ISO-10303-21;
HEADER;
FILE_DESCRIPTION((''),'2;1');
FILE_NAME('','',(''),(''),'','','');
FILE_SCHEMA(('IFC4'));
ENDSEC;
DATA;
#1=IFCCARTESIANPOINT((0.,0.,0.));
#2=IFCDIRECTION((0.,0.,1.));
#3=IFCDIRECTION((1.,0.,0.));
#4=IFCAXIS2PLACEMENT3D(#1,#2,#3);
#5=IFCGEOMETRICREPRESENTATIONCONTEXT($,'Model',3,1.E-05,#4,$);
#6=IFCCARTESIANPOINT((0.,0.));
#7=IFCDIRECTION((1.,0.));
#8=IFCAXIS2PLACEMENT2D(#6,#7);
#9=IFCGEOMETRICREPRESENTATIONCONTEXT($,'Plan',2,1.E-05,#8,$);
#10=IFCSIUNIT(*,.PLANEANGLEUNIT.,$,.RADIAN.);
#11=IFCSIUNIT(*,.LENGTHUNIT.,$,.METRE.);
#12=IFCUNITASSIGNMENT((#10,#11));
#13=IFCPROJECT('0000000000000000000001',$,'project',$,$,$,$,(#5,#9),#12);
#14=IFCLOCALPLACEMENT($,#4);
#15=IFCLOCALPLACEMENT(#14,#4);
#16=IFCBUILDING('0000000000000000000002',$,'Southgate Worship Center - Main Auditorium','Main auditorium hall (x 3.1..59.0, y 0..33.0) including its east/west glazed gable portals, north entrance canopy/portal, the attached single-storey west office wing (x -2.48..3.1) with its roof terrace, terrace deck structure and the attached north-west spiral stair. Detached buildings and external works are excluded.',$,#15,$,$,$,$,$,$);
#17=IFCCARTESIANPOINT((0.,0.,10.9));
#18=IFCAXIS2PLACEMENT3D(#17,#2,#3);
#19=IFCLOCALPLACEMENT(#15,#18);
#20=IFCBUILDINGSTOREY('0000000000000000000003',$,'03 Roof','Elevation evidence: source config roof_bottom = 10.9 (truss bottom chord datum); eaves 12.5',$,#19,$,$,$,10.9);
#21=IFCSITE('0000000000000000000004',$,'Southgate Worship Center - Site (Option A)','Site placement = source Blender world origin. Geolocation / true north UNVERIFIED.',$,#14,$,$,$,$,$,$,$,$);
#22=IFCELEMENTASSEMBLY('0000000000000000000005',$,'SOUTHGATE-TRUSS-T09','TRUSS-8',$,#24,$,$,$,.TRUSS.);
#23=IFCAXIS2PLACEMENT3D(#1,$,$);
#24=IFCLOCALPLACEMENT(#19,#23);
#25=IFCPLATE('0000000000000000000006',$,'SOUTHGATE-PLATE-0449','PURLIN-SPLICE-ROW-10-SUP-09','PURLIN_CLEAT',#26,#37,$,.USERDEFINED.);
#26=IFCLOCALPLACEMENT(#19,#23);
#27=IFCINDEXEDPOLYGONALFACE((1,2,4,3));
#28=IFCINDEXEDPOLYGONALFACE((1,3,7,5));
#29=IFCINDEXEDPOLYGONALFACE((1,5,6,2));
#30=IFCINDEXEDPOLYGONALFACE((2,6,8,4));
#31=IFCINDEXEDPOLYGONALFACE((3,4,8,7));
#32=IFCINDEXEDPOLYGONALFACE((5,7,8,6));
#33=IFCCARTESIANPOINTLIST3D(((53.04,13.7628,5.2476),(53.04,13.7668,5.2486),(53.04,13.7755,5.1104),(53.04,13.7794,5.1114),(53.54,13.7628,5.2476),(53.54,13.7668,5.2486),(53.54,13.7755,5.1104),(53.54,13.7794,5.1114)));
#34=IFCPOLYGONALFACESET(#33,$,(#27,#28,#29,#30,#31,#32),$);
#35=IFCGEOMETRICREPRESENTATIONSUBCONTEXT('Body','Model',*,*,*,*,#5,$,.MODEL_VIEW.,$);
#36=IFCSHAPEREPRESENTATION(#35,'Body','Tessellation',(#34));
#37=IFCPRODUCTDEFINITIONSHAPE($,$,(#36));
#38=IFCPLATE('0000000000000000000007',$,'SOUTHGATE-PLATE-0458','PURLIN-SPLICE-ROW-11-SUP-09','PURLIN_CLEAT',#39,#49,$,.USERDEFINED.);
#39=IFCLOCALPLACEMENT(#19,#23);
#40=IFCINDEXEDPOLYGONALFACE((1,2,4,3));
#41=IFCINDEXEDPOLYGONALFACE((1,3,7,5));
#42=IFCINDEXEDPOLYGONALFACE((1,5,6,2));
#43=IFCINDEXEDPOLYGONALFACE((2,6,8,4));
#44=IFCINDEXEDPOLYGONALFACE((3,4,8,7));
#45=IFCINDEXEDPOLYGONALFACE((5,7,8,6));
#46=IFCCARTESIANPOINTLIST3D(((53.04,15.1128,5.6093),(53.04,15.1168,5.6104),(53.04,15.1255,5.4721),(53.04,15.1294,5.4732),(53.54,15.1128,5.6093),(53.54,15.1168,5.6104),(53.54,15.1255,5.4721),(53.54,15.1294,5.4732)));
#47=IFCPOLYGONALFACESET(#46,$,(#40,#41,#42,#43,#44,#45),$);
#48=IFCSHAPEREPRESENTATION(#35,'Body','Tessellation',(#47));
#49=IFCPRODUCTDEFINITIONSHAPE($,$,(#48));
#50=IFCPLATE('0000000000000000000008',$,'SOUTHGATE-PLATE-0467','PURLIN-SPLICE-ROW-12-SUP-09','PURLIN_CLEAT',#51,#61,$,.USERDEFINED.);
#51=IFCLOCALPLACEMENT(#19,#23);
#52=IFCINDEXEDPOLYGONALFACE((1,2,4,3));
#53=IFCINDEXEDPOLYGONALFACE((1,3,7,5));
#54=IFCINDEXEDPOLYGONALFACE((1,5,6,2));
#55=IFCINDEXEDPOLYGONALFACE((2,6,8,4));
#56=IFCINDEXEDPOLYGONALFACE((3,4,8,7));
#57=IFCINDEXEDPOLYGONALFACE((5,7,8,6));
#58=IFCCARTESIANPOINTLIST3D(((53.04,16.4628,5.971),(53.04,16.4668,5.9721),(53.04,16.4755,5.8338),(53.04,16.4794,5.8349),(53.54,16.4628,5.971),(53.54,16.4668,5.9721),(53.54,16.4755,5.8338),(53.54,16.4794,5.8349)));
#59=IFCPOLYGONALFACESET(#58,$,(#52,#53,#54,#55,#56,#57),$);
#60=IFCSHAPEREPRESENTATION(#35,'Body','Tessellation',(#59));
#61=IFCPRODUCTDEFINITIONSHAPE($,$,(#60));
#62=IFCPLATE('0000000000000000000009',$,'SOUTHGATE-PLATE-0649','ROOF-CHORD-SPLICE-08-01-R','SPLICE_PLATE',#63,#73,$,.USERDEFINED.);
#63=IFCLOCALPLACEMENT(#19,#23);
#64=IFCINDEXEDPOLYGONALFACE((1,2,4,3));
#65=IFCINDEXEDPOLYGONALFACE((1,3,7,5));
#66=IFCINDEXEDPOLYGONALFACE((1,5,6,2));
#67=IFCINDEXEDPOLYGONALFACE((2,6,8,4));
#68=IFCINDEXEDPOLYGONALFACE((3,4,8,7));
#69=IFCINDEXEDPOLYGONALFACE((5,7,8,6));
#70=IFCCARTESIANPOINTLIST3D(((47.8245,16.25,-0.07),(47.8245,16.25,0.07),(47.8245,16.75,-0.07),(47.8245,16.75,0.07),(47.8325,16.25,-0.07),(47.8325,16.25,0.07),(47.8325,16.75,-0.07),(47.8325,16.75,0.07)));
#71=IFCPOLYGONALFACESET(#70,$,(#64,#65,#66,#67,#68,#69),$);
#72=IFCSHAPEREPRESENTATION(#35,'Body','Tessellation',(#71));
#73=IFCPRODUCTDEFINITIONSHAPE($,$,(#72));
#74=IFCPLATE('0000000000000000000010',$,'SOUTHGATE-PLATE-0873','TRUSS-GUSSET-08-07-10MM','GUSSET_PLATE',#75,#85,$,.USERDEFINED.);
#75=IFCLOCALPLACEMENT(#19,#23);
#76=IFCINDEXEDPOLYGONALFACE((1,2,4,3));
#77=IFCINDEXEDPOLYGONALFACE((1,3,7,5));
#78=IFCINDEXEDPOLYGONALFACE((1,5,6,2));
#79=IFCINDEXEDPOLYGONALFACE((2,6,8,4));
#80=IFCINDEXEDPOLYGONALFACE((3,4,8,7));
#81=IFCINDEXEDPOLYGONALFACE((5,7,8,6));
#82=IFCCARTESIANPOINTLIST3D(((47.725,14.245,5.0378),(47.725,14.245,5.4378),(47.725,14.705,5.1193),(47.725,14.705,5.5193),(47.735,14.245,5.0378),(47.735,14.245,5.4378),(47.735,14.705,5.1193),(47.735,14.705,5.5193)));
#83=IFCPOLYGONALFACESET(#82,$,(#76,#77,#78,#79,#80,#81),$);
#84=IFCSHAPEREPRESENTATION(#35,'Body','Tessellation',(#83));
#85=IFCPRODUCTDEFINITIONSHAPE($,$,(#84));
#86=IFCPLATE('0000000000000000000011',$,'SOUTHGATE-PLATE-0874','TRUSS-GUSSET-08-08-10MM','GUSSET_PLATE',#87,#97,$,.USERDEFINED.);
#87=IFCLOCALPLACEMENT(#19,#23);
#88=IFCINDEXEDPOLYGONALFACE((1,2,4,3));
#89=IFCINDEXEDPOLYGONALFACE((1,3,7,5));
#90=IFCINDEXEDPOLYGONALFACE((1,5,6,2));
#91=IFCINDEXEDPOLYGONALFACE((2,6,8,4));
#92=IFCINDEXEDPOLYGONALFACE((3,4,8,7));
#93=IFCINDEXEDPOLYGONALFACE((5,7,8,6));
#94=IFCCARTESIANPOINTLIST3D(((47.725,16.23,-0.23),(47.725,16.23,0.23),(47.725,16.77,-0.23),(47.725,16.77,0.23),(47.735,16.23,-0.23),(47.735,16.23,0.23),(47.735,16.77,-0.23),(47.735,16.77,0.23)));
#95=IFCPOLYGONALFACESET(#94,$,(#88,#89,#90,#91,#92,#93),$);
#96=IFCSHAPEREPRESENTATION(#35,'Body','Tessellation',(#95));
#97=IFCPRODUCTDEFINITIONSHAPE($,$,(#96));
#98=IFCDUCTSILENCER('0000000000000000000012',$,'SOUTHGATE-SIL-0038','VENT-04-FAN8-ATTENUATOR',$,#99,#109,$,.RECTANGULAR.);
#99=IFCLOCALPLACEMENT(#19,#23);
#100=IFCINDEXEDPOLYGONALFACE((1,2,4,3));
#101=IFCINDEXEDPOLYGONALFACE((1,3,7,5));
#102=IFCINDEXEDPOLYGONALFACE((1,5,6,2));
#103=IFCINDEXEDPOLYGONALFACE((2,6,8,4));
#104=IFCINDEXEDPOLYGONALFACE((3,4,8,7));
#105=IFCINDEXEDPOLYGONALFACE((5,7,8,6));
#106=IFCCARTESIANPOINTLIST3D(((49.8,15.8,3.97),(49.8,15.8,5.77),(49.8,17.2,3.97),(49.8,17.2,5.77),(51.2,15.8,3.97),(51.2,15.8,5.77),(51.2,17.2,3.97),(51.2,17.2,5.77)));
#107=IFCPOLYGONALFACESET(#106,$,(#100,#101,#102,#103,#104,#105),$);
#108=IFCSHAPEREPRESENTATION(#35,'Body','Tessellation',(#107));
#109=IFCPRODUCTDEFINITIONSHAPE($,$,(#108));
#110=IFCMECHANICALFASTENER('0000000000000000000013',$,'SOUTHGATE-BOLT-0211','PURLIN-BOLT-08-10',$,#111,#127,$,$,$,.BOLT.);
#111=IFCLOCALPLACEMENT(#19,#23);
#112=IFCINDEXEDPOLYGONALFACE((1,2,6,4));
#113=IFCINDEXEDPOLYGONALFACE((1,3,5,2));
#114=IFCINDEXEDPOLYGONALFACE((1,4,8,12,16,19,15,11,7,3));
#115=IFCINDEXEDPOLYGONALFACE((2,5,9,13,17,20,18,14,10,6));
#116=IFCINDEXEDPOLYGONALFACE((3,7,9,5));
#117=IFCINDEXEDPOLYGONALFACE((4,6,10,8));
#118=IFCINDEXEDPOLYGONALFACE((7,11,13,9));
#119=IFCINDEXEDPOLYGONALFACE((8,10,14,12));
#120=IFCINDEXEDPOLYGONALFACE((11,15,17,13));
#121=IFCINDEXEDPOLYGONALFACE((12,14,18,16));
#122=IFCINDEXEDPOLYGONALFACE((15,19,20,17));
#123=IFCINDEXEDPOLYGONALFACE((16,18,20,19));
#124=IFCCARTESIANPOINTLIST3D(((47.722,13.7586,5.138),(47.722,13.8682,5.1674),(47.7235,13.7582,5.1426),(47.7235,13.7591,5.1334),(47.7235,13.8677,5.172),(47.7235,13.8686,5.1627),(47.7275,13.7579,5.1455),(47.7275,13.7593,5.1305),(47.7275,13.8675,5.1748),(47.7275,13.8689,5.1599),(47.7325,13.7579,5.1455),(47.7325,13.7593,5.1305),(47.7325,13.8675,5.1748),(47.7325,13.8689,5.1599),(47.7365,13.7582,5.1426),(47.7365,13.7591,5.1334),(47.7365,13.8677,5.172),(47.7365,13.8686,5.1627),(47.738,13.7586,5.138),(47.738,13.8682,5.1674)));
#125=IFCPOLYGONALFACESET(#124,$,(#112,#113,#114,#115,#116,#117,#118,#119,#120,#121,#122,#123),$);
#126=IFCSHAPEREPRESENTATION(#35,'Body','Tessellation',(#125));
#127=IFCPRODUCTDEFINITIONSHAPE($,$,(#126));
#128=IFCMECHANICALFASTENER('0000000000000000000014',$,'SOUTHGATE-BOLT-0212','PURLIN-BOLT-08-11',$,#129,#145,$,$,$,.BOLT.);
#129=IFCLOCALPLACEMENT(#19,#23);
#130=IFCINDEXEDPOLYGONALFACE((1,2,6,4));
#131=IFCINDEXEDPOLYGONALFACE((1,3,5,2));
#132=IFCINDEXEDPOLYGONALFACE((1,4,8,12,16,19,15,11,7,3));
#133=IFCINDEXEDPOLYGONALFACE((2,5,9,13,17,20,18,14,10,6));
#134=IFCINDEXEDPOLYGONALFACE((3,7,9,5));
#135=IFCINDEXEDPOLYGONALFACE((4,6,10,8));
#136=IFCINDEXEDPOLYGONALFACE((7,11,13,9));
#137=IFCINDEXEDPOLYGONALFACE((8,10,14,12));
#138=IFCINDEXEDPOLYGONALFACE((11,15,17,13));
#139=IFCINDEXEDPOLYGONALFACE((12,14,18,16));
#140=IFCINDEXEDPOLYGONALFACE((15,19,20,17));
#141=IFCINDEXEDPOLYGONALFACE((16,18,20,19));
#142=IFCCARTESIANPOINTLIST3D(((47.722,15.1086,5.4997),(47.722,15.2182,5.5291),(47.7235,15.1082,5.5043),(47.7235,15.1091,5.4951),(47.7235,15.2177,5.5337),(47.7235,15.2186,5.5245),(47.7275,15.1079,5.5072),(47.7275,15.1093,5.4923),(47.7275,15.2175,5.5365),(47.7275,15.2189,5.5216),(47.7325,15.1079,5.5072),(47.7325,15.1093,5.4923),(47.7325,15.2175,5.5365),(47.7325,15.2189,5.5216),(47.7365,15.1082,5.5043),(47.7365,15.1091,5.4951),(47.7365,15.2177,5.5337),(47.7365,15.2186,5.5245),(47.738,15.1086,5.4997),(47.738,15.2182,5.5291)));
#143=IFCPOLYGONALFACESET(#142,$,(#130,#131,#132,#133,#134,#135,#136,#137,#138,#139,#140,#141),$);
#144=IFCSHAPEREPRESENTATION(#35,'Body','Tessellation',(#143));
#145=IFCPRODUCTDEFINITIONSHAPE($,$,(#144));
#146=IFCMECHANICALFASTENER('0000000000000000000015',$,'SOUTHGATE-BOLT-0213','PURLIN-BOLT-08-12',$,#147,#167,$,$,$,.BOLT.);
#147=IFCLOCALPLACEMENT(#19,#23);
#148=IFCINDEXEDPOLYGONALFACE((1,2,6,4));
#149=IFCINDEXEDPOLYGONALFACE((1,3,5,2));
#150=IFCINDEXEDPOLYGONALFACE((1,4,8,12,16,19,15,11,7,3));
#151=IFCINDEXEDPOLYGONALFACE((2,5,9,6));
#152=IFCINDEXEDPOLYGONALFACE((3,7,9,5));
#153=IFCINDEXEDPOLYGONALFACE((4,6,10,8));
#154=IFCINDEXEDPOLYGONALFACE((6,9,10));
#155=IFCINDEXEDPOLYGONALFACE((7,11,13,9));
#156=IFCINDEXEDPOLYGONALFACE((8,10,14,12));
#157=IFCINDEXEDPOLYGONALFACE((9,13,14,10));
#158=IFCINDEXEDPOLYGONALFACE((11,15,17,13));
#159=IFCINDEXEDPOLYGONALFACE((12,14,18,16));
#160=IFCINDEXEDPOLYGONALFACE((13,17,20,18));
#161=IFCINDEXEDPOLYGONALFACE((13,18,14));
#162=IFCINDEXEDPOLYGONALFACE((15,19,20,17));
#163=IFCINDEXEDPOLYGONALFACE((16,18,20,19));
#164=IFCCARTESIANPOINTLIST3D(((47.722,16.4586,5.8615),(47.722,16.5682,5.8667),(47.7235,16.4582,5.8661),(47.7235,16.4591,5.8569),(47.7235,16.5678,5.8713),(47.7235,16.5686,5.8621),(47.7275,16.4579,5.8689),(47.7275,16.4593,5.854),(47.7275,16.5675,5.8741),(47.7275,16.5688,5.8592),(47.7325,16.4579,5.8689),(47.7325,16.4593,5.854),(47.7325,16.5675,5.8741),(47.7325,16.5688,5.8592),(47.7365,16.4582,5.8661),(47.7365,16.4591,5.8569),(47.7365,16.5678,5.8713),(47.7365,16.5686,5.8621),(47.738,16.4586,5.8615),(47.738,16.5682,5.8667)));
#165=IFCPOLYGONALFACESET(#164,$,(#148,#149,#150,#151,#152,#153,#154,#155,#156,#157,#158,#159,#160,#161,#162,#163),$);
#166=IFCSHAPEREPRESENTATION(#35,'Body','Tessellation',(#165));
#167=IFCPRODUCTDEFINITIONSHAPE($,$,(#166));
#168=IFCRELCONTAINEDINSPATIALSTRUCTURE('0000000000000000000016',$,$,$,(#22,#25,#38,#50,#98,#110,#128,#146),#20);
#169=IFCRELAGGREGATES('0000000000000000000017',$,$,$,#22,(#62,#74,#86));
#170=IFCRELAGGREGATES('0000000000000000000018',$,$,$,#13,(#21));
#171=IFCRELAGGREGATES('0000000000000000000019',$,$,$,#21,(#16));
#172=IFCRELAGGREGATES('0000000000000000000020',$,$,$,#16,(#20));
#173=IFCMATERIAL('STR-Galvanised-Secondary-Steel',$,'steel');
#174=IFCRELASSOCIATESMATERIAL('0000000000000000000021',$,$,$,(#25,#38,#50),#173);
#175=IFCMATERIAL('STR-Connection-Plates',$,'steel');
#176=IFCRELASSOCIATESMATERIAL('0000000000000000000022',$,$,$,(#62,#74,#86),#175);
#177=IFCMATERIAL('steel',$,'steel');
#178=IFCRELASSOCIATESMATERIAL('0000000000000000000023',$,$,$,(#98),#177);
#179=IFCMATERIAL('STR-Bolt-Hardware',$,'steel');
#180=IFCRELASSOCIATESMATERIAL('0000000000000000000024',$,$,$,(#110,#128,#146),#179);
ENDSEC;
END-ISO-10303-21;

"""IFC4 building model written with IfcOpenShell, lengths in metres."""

from ifc_helpers import new_model, si_unit, frame, origin_with_axes, origin_2d, origin_2d_with_axis, place, context, subcontext, project, spatial, indexed_curve, rectangle, outline, extrude, clip, halfspace, material, element, aggregate, save


model = new_model("IFC4")

# Units and contexts
model_context = context("Model", 3, precision=1e-05, world=origin_with_axes())
plan_context = context("Plan", 2, precision=1e-05, world=origin_2d_with_axis())
body_context = subcontext(model_context, "Body", "Model", "MODEL_VIEW")
ifc_project = project(units=[si_unit("PLANEANGLEUNIT", "RADIAN"), si_unit("LENGTHUNIT", "METRE")], contexts=[model_context, plan_context])

# Site, building, storey
site_placement = place(None, origin_with_axes())
site = spatial("IfcSite", under=ifc_project, at=site_placement, Name="Southgate Worship Center - Site (Option A)", Description="Site placement = source Blender world origin. Geolocation / true north UNVERIFIED.")
building_placement = place(site_placement, origin_with_axes())
building = spatial("IfcBuilding", under=site, at=building_placement, Name="Southgate Worship Center - Main Auditorium", Description="Main auditorium hall (x 3.1..59.0, y 0..33.0) including its east/west glazed gable portals, north entrance canopy/portal, the attached single-storey west office wing (x -2.48..3.1) with its roof terrace, terrace deck structure and the attached north-west spiral stair. Detached buildings and external works are excluded.")
storey_placement = place(building_placement, frame((0.0, 0.0, 10.9), z_axis=(0.0, 0.0, 1.0), x_axis=(1.0, 0.0, 0.0)))
storey = spatial("IfcBuildingStorey", under=building, at=storey_placement, Name="03 Roof", Description="Elevation evidence: source config roof_bottom = 10.9 (truss bottom chord datum); eaves 12.5", Elevation=10.9)

# Shared definitions
ifc_material_1 = material(Name="STR-Galvanised-Secondary-Steel", Category="steel")

# Element assembly
assembly_1_placement = place(storey_placement, origin_with_axes())
assembly_1 = element("IfcElementAssembly", 1, at=assembly_1_placement, inside=storey, Name="SOUTHGATE-TRUSS-T09", Description="TRUSS-8", PredefinedType="TRUSS")

# Plates
plate_1_placement = place(storey_placement, frame((53.04, 13.7628, 5.1104), z_axis=(1.0, 0.0, 0.0), x_axis=(0.0, 1.0, 0.0)))
element("IfcPlate", 2, at=plate_1_placement, inside=storey, material=ifc_material_1, Name="SOUTHGATE-PLATE-0449", Description="PURLIN-SPLICE-ROW-10-SUP-09", ObjectType="PURLIN_CLEAT", PredefinedType="USERDEFINED", context=body_context, shape_type="SweptSolid", body=[
    extrude(outline(indexed_curve([(0.0, 0.0), (0.004, 0.0011), (-0.0087, 0.1382), (-0.0127, 0.1372), (0.0, 0.0)], self_intersect=False)), frame((0.0127, 0.0, 0.0), z_axis=(0.0, 0.0, 1.0), x_axis=(1.0, 0.0, 0.0)), (0.0, 0.0, 1.0), 0.5),
])
plate_2_placement = place(storey_placement, frame((53.04, 15.1128, 5.4721), z_axis=(1.0, 0.0, 0.0), x_axis=(0.0, 1.0, 0.0)))
element("IfcPlate", 3, at=plate_2_placement, inside=storey, material=ifc_material_1, Name="SOUTHGATE-PLATE-0458", Description="PURLIN-SPLICE-ROW-11-SUP-09", ObjectType="PURLIN_CLEAT", PredefinedType="USERDEFINED", context=body_context, shape_type="SweptSolid", body=[
    extrude(outline(indexed_curve([(0.0, 0.0), (0.004, 0.0011), (-0.0087, 0.1382), (-0.0127, 0.1372), (0.0, 0.0)], self_intersect=False)), frame((0.0127, 0.0, 0.0), z_axis=(0.0, 0.0, 1.0), x_axis=(1.0, 0.0, 0.0)), (0.0, 0.0, 1.0), 0.5),
])
plate_3_placement = place(storey_placement, frame((53.04, 16.4628, 5.8338), z_axis=(1.0, 0.0, 0.0), x_axis=(0.0, 1.0, 0.0)))
element("IfcPlate", 4, at=plate_3_placement, inside=storey, material=ifc_material_1, Name="SOUTHGATE-PLATE-0467", Description="PURLIN-SPLICE-ROW-12-SUP-09", ObjectType="PURLIN_CLEAT", PredefinedType="USERDEFINED", context=body_context, shape_type="SweptSolid", body=[
    extrude(outline(indexed_curve([(0.0, 0.0), (0.004, 0.0011), (-0.0087, 0.1382), (-0.0127, 0.1372), (0.0, 0.0)], self_intersect=False)), frame((0.0127, 0.0, 0.0), z_axis=(0.0, 0.0, 1.0), x_axis=(1.0, 0.0, 0.0)), (0.0, 0.0, 1.0), 0.5),
])

# Plates
ifc_material_2 = material(Name="STR-Connection-Plates", Category="steel")
plate_4_placement = place(assembly_1_placement, frame((47.8245, 16.25, -0.07), z_axis=(0.0, 0.0, 1.0), x_axis=(1.0, 0.0, 0.0)))
plate_4 = element("IfcPlate", 5, at=plate_4_placement, material=ifc_material_2, Name="SOUTHGATE-PLATE-0649", Description="ROOF-CHORD-SPLICE-08-01-R", ObjectType="SPLICE_PLATE", PredefinedType="USERDEFINED", context=body_context, shape_type="SweptSolid", body=[
    extrude(rectangle(XDim=0.008, YDim=0.5, at=origin_2d()), frame((0.004, 0.25, 0.0), z_axis=(0.0, 0.0, 1.0), x_axis=(1.0, 0.0, 0.0)), (0.0, 0.0, 1.0), 0.14),
])
plate_5_placement = place(assembly_1_placement, frame((47.725, 14.245, 5.0378), z_axis=(1.0, 0.0, 0.0), x_axis=(0.0, 1.0, 0.0)))
plate_5 = element("IfcPlate", 6, at=plate_5_placement, material=ifc_material_2, Name="SOUTHGATE-PLATE-0873", Description="TRUSS-GUSSET-08-07-10MM", ObjectType="GUSSET_PLATE", PredefinedType="USERDEFINED", context=body_context, shape_type="SweptSolid", body=[
    extrude(outline(indexed_curve([(0.0, 0.0), (0.0, 0.4), (-0.46, 0.3186), (-0.46, -0.0814), (0.0, 0.0)], self_intersect=False)), frame((0.46, 0.0814, 0.0), z_axis=(0.0, 0.0, 1.0), x_axis=(1.0, 0.0, 0.0)), (0.0, 0.0, 1.0), 0.01),
])
plate_6_placement = place(assembly_1_placement, frame((47.725, 16.23, -0.23), z_axis=(0.0, 0.0, 1.0), x_axis=(1.0, 0.0, 0.0)))
plate_6 = element("IfcPlate", 7, at=plate_6_placement, material=ifc_material_2, Name="SOUTHGATE-PLATE-0874", Description="TRUSS-GUSSET-08-08-10MM", ObjectType="GUSSET_PLATE", PredefinedType="USERDEFINED", context=body_context, shape_type="SweptSolid", body=[
    extrude(rectangle(XDim=0.01, YDim=0.54, at=origin_2d()), frame((0.005, 0.27, 0.0), z_axis=(0.0, 0.0, 1.0), x_axis=(1.0, 0.0, 0.0)), (0.0, 0.0, 1.0), 0.46),
])

# Duct silencer
ifc_material_3 = material(Name="steel", Category="steel")
duct_silencer_placement = place(storey_placement, frame((49.8, 15.8, 3.97), z_axis=(0.0, 0.0, 1.0), x_axis=(1.0, 0.0, 0.0)))
element("IfcDuctSilencer", 8, at=duct_silencer_placement, inside=storey, material=ifc_material_3, Name="SOUTHGATE-SIL-0038", Description="VENT-04-FAN8-ATTENUATOR", PredefinedType="RECTANGULAR", context=body_context, shape_type="SweptSolid", body=[
    extrude(rectangle(XDim=1.4, YDim=1.4, at=origin_2d()), frame((0.7, 0.7, 0.0), z_axis=(0.0, 0.0, 1.0), x_axis=(0.0, 1.0, 0.0)), (0.0, 0.0, 1.0), 1.8),
])

# Mechanical fasteners
ifc_material_4 = material(Name="STR-Bolt-Hardware", Category="steel")
mechanical_fastener_1_placement = place(storey_placement, frame((47.722, 13.7579, 5.1305), z_axis=(0.0, 0.0, 1.0), x_axis=(1.0, 0.0, 0.0)))
element("IfcMechanicalFastener", 9, at=mechanical_fastener_1_placement, inside=storey, material=ifc_material_4, Name="SOUTHGATE-BOLT-0211", Description="PURLIN-BOLT-08-10", PredefinedType="BOLT", context=body_context, shape_type="Clipping", body=[
    clip(clip(extrude(outline(indexed_curve([(0.0, 0.0), (-0.004, -0.0028), (-0.0055, -0.0074), (-0.004, -0.0119), (0.0, -0.0148), (0.0049, -0.0148), (0.0089, -0.0119), (0.0105, -0.0074), (0.0089, -0.0028), (0.0049, 0.0), (0.0, 0.0)], self_intersect=False)), frame((0.0105, -0.0024, 0.0143), z_axis=(0.0, 0.965929, 0.258809), x_axis=(-1.0, 0.0, 0.0)), (0.0, 0.0, 1.0), 0.1159), halfspace(frame((0.008, 0.0007, 0.0075), z_axis=(0.0, -0.995763, -0.09196), x_axis=(1.0, 0.0, 0.0)), False)), halfspace(frame((0.008, 0.1103, 0.0369), z_axis=(0.0, 0.995763, 0.09196), x_axis=(-1.0, 0.0, 0.0)), False)),
])
mechanical_fastener_2_placement = place(storey_placement, frame((47.722, 15.1079, 5.4923), z_axis=(0.0, 0.0, 1.0), x_axis=(1.0, 0.0, 0.0)))
element("IfcMechanicalFastener", 10, at=mechanical_fastener_2_placement, inside=storey, material=ifc_material_4, Name="SOUTHGATE-BOLT-0212", Description="PURLIN-BOLT-08-11", PredefinedType="BOLT", context=body_context, shape_type="Clipping", body=[
    clip(clip(extrude(outline(indexed_curve([(0.0, 0.0), (-0.004, -0.0028), (-0.0055, -0.0074), (-0.004, -0.0119), (0.0, -0.0148), (0.0049, -0.0148), (0.0089, -0.0119), (0.0105, -0.0074), (0.0089, -0.0028), (0.0049, 0.0), (0.0, 0.0)], self_intersect=False)), frame((0.0105, -0.0024, 0.0142), z_axis=(0.0, 0.965924, 0.258824), x_axis=(-1.0, 0.0, 0.0)), (0.0, 0.0, 1.0), 0.1159), halfspace(frame((0.008, 0.0007, 0.0074), z_axis=(0.0, -0.995763, -0.09196), x_axis=(1.0, 0.0, 0.0)), False)), halfspace(frame((0.008, 0.1103, 0.0368), z_axis=(0.0, 0.995764, 0.091951), x_axis=(-1.0, 0.0, 0.0)), False)),
])
mechanical_fastener_3_placement = place(storey_placement, frame((47.722, 16.4579, 5.854), z_axis=(0.0, 0.0, 1.0), x_axis=(1.0, 0.0, 0.0)))
element("IfcMechanicalFastener", 11, at=mechanical_fastener_3_placement, inside=storey, material=ifc_material_4, Name="SOUTHGATE-BOLT-0213", Description="PURLIN-BOLT-08-12", PredefinedType="BOLT", context=body_context, shape_type="Clipping", body=[
    clip(clip(extrude(outline(indexed_curve([(0.0, 0.0), (-0.004, -0.0029), (-0.0055, -0.0075), (-0.004, -0.0121), (0.0, -0.015), (0.0049, -0.015), (0.0089, -0.0121), (0.0105, -0.0075), (0.0089, -0.0029), (0.0049, 0.0), (0.0, 0.0)], self_intersect=False)), frame((0.0105, 0.0, 0.0149), z_axis=(0.0, 0.99887, 0.047535), x_axis=(-1.0, 0.0, 0.0)), (0.0, 0.0, 1.0), 0.1103), halfspace(frame((0.008, 0.0007, 0.0075), z_axis=(0.0, -0.995763, -0.09196), x_axis=(1.0, 0.0, 0.0)), False)), halfspace(frame((0.008, 0.1103, 0.0127), z_axis=(0.0, 0.996026, 0.089068), x_axis=(-1.0, 0.0, 0.0)), False)),
])

aggregate(assembly_1, [plate_4, plate_5, plate_6])

save(model, "model.ifc")
